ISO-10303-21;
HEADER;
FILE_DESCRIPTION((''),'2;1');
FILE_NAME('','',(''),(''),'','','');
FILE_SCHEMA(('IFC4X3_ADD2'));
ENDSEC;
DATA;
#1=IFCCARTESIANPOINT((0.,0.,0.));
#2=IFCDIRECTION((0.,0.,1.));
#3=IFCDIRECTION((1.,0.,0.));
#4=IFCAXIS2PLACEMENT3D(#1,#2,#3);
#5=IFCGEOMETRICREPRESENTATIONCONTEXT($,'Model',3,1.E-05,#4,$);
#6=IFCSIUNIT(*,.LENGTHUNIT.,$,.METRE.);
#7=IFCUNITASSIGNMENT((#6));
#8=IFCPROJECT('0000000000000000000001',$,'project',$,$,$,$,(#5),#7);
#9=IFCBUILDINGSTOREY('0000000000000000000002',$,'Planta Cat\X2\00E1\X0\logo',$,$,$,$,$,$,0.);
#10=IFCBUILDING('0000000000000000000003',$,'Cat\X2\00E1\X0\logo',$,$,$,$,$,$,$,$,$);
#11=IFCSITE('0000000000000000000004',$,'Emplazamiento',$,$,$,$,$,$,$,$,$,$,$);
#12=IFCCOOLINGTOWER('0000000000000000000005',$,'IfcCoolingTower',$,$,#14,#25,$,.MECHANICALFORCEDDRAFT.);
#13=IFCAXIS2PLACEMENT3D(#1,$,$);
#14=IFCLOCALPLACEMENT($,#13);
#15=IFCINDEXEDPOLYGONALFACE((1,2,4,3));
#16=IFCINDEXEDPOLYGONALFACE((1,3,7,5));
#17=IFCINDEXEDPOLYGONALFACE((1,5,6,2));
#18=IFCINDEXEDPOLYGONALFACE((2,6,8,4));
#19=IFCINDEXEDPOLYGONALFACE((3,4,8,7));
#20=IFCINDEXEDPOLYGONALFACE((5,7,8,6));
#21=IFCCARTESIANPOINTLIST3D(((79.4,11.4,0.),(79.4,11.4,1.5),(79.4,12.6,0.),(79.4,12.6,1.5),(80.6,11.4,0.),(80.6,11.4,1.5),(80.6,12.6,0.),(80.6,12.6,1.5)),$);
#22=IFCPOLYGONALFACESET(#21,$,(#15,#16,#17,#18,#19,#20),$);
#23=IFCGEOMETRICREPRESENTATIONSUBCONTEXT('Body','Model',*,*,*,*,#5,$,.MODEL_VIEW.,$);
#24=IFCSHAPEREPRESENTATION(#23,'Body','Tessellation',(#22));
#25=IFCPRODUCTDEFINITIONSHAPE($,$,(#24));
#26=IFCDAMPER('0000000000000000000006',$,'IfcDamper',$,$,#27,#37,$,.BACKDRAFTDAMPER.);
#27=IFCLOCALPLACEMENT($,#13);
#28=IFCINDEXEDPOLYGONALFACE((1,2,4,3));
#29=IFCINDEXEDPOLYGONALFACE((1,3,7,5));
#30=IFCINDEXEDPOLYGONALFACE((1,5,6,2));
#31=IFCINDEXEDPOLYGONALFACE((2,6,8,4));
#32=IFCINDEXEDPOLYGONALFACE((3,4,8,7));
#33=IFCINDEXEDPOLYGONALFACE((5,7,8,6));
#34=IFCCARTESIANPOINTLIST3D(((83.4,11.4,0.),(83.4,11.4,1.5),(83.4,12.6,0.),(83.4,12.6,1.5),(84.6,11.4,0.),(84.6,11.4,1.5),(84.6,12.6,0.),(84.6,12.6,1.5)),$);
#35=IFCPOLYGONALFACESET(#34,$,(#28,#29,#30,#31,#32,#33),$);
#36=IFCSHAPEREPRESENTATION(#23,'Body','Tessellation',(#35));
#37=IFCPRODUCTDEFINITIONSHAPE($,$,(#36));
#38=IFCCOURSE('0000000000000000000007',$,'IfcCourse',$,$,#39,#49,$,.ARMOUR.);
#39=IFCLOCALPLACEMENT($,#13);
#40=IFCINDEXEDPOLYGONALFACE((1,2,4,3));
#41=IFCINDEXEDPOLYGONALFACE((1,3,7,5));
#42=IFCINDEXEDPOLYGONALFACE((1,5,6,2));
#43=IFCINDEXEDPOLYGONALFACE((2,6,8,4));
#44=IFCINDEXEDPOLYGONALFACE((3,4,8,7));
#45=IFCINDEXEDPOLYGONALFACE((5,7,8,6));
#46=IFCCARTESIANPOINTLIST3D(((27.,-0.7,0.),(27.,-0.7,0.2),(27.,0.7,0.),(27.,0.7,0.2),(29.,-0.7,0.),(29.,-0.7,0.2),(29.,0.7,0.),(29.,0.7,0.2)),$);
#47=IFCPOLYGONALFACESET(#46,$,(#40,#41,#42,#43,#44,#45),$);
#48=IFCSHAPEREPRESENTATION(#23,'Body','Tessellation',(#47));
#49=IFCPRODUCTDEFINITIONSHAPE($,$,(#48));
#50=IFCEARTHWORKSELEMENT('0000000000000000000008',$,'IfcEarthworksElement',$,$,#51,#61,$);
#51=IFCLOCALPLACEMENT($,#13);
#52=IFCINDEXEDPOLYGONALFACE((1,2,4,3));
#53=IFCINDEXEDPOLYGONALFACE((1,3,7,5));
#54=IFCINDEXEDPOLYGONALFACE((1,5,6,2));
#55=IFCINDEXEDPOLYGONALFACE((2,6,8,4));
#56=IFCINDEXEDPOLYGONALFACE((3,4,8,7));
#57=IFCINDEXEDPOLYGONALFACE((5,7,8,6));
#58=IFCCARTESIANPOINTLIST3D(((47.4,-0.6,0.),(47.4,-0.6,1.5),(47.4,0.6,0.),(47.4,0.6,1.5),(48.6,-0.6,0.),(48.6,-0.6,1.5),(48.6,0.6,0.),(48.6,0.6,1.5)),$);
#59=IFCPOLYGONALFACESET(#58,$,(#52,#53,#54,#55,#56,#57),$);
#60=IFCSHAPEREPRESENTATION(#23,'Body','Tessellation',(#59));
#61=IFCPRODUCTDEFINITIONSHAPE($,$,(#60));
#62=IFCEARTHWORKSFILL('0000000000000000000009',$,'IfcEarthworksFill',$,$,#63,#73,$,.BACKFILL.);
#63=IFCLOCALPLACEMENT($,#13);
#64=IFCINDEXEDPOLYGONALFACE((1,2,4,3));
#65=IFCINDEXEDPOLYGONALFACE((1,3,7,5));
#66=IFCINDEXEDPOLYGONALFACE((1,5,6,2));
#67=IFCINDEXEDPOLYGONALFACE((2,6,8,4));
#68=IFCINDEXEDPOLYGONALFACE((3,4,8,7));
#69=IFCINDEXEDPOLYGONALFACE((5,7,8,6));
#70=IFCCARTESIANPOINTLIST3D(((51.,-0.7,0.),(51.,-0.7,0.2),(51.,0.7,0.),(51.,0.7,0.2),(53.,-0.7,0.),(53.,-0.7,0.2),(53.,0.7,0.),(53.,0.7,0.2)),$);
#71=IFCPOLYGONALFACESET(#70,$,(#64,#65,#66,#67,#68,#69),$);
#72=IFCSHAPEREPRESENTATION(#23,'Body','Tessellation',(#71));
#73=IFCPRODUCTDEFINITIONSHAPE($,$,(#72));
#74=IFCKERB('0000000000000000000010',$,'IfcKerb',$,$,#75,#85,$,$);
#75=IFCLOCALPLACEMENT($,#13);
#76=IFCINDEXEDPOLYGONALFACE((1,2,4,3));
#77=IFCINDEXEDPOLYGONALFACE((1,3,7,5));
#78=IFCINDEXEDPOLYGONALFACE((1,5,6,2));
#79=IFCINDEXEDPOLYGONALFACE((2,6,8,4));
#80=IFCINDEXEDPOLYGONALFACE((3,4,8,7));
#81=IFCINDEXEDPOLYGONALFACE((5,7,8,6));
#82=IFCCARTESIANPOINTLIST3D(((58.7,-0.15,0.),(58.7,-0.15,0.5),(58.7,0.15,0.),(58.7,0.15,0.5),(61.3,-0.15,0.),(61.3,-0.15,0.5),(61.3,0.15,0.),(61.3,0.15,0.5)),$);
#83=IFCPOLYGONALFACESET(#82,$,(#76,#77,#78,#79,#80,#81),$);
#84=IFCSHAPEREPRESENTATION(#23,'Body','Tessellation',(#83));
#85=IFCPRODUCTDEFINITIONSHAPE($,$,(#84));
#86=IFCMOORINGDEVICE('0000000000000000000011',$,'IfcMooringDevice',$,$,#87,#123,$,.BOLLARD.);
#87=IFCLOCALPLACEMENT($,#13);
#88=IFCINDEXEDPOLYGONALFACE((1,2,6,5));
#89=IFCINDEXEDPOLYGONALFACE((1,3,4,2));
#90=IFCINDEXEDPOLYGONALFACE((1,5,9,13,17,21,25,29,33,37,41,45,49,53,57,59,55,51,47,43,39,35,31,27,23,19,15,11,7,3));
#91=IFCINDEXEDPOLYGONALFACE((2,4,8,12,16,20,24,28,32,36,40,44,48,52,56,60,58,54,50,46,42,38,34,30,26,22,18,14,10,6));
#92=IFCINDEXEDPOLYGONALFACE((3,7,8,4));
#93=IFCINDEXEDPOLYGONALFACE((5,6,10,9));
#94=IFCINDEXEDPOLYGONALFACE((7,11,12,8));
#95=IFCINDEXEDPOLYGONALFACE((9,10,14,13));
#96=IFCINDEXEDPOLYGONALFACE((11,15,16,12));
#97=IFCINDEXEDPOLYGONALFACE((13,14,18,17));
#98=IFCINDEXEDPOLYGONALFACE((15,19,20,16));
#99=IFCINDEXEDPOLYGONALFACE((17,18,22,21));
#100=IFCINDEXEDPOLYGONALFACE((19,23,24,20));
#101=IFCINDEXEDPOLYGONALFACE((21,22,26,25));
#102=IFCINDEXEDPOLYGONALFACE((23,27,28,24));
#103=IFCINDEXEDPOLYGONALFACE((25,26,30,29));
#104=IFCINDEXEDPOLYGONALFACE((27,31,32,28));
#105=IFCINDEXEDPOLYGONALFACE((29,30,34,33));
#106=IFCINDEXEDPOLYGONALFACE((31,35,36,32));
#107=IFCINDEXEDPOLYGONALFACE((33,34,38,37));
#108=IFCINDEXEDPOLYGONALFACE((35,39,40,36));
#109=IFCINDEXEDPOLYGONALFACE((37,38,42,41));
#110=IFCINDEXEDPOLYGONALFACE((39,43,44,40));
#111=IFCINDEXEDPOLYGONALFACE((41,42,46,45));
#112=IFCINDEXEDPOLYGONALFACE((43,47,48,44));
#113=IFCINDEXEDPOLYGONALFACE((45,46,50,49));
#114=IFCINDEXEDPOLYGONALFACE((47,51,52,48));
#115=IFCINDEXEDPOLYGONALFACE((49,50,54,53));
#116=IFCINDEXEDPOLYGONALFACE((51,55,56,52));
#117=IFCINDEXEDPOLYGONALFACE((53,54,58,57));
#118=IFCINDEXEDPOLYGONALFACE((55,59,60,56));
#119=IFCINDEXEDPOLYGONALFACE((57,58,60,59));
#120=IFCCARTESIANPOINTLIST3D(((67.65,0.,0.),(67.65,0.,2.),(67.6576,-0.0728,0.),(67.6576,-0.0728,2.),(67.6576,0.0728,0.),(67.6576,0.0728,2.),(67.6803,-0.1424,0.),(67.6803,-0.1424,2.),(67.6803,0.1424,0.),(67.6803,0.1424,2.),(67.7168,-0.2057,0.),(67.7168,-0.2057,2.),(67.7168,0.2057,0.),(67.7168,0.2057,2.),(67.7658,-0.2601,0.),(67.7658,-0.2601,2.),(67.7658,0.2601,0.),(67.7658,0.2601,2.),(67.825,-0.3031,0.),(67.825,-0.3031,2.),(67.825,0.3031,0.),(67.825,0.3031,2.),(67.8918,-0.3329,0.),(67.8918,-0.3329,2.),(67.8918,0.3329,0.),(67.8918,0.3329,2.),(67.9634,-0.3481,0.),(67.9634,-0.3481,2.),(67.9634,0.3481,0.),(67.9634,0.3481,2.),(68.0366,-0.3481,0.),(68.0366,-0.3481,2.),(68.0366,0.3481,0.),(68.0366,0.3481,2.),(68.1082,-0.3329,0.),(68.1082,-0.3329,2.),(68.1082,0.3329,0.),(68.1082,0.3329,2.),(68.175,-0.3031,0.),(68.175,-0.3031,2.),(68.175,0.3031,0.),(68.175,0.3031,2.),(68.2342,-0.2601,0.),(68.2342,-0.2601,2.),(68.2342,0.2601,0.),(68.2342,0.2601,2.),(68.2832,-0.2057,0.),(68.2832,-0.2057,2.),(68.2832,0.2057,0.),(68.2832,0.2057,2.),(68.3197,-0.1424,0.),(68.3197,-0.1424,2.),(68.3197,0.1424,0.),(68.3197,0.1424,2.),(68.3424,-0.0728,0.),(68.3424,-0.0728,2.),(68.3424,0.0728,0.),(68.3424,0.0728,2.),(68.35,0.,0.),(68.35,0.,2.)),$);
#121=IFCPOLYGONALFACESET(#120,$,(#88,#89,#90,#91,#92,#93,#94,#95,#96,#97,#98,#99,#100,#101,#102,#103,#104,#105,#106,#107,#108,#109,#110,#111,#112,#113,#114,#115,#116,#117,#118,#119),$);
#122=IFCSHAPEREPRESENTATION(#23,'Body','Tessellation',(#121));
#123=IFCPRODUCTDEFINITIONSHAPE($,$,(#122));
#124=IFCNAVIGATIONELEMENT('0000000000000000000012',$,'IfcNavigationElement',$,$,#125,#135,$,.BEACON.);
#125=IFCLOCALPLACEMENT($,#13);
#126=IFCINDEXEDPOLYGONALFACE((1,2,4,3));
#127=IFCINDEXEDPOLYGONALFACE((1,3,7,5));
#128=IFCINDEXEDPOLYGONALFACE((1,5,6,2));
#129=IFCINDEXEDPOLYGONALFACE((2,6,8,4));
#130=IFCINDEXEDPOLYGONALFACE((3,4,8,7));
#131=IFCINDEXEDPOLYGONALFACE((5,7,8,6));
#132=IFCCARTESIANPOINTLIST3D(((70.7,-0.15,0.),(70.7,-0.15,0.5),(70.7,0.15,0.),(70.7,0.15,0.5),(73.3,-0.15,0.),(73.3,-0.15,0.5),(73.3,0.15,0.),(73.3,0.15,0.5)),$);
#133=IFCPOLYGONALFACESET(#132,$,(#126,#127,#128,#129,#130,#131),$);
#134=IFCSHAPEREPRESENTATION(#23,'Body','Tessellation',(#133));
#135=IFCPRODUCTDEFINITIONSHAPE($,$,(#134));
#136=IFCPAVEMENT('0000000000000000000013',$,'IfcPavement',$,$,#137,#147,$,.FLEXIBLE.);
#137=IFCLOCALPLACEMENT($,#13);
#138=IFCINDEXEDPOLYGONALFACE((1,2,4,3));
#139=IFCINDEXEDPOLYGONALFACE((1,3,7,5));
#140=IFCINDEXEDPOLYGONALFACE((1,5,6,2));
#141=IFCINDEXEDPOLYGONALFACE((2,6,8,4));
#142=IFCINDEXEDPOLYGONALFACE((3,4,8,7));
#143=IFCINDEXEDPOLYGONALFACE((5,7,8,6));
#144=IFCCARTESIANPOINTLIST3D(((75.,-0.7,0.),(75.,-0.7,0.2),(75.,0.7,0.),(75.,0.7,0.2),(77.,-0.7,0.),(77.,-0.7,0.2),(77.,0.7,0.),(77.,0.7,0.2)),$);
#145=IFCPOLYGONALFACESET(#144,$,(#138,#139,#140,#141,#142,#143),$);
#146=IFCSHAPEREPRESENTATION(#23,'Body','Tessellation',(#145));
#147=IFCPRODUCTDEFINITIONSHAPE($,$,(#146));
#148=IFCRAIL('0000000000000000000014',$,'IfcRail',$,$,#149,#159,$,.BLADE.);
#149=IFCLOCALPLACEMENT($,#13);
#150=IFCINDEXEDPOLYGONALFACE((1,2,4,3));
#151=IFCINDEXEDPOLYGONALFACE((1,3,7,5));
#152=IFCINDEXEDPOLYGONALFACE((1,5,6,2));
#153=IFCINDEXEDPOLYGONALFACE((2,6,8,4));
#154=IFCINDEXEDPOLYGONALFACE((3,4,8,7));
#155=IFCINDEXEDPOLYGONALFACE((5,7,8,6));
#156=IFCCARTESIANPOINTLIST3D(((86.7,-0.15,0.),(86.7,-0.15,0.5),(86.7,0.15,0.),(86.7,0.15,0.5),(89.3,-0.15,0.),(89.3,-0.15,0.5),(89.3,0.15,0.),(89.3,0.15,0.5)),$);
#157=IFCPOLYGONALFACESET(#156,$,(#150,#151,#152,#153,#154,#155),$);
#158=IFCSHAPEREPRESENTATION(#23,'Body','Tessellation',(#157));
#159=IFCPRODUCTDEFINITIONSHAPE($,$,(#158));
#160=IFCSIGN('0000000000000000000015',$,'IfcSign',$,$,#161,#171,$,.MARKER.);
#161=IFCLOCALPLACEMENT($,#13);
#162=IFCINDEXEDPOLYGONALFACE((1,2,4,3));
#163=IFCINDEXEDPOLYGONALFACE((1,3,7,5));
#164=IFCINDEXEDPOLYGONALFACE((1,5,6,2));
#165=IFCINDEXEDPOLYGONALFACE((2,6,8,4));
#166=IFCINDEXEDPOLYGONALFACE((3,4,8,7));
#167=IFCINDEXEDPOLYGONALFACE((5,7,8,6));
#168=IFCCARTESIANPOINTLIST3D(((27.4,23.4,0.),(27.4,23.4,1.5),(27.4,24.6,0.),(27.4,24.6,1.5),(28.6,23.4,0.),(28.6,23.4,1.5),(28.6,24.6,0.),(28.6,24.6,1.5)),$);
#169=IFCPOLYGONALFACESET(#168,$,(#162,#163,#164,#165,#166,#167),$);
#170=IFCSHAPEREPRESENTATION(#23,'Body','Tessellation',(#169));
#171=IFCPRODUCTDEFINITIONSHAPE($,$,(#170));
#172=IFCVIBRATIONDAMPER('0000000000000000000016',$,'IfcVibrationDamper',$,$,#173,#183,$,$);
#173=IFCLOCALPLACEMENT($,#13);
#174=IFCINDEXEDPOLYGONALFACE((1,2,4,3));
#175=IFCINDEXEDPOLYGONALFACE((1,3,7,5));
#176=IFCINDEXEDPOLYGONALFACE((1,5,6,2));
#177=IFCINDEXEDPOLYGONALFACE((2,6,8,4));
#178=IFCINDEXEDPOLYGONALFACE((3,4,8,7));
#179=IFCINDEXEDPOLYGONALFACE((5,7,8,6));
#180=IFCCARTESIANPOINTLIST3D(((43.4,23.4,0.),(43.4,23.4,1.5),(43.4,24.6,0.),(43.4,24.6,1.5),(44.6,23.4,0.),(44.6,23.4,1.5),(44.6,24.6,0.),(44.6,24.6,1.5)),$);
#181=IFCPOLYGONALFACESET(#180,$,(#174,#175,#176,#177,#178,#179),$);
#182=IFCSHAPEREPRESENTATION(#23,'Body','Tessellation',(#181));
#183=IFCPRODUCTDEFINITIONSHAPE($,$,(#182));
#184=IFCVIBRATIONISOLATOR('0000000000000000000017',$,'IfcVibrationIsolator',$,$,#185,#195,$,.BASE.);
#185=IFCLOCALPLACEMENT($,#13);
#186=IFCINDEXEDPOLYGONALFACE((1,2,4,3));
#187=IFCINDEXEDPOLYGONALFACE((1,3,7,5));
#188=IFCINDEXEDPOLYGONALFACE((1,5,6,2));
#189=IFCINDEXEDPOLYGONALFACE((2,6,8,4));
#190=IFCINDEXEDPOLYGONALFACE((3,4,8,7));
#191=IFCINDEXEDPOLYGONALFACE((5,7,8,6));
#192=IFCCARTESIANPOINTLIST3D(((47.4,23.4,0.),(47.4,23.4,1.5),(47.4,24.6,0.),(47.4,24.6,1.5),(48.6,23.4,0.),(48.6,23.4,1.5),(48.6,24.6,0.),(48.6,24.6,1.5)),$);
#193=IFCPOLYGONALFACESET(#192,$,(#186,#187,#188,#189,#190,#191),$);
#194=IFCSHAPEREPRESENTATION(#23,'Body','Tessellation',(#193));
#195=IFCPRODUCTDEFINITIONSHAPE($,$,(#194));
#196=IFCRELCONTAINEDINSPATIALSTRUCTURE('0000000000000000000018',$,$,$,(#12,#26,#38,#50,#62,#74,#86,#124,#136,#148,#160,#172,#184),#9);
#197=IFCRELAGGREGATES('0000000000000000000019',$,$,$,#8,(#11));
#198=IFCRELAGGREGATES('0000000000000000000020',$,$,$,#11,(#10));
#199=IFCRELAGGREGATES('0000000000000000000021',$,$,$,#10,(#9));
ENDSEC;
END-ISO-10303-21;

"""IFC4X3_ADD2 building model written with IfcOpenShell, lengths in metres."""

from ifc_helpers import new_model, si_unit, frame, origin, origin_with_axes, origin_2d, place, context, subcontext, project, spatial, rectangle, circle, extrude, element, save


model = new_model("IFC4X3_ADD2")

# Units and contexts
model_context = context("Model", 3, precision=1e-05, world=origin_with_axes())
body_context = subcontext(model_context, "Body", "Model", "MODEL_VIEW")
ifc_project = project(units=[si_unit("LENGTHUNIT", "METRE")], contexts=[model_context])

# Site, building, storey
site = spatial("IfcSite", under=ifc_project, Name="Emplazamiento")
building = spatial("IfcBuilding", under=site, Name="Catálogo")
storey = spatial("IfcBuildingStorey", under=building, Name="Planta Catálogo", Elevation=0.0)

# Cooling tower
cooling_tower_placement = place(None, frame((80.0, 12.0, 0.0), z_axis=(0.0, 0.0, 1.0), x_axis=(1.0, 0.0, 0.0)))
element("IfcCoolingTower", 1, at=cooling_tower_placement, inside=storey, Name="IfcCoolingTower", PredefinedType="MECHANICALFORCEDDRAFT", context=body_context, shape_type="SweptSolid", body=[
    extrude(rectangle(XDim=1.2, YDim=1.2, at=origin_2d()), origin(), (0.0, 0.0, 1.0), 1.5),
])

# Damper
damper_placement = place(None, frame((84.0, 12.0, 0.0), z_axis=(0.0, 0.0, 1.0), x_axis=(1.0, 0.0, 0.0)))
element("IfcDamper", 2, at=damper_placement, inside=storey, Name="IfcDamper", PredefinedType="BACKDRAFTDAMPER", context=body_context, shape_type="SweptSolid", body=[
    extrude(rectangle(XDim=1.2, YDim=1.2, at=origin_2d()), origin(), (0.0, 0.0, 1.0), 1.5),
])

# Course
course_placement = place(None, frame((28.0, 0.0, 0.0), z_axis=(0.0, 0.0, 1.0), x_axis=(1.0, 0.0, 0.0)))
element("IfcCourse", 3, at=course_placement, inside=storey, Name="IfcCourse", PredefinedType="ARMOUR", context=body_context, shape_type="SweptSolid", body=[
    extrude(rectangle(XDim=2.0, YDim=1.4, at=origin_2d()), origin(), (0.0, 0.0, 1.0), 0.2),
])

# Earthworks element
earthworks_element_placement = place(None, frame((48.0, 0.0, 0.0), z_axis=(0.0, 0.0, 1.0), x_axis=(1.0, 0.0, 0.0)))
element("IfcEarthworksElement", 4, at=earthworks_element_placement, inside=storey, Name="IfcEarthworksElement", context=body_context, shape_type="SweptSolid", body=[
    extrude(rectangle(XDim=1.2, YDim=1.2, at=origin_2d()), origin(), (0.0, 0.0, 1.0), 1.5),
])

# Earthworks fill
earthworks_fill_placement = place(None, frame((52.0, 0.0, 0.0), z_axis=(0.0, 0.0, 1.0), x_axis=(1.0, 0.0, 0.0)))
element("IfcEarthworksFill", 5, at=earthworks_fill_placement, inside=storey, Name="IfcEarthworksFill", PredefinedType="BACKFILL", context=body_context, shape_type="SweptSolid", body=[
    extrude(rectangle(XDim=2.0, YDim=1.4, at=origin_2d()), origin(), (0.0, 0.0, 1.0), 0.2),
])

# Kerb
kerb_placement = place(None, frame((60.0, 0.0, 0.0), z_axis=(0.0, 0.0, 1.0), x_axis=(1.0, 0.0, 0.0)))
element("IfcKerb", 6, at=kerb_placement, inside=storey, Name="IfcKerb", context=body_context, shape_type="SweptSolid", body=[
    extrude(rectangle(XDim=2.6, YDim=0.3, at=origin_2d()), origin(), (0.0, 0.0, 1.0), 0.5),
])

# Mooring device
mooring_device_placement = place(None, frame((68.0, 0.0, 0.0), z_axis=(0.0, 0.0, 1.0), x_axis=(1.0, 0.0, 0.0)))
element("IfcMooringDevice", 7, at=mooring_device_placement, inside=storey, Name="IfcMooringDevice", PredefinedType="BOLLARD", context=body_context, shape_type="SweptSolid", body=[
    extrude(circle(Radius=0.35, at=origin_2d()), origin(), (0.0, 0.0, 1.0), 2.0),
])

# Navigation element
navigation_element_placement = place(None, frame((72.0, 0.0, 0.0), z_axis=(0.0, 0.0, 1.0), x_axis=(1.0, 0.0, 0.0)))
element("IfcNavigationElement", 8, at=navigation_element_placement, inside=storey, Name="IfcNavigationElement", PredefinedType="BEACON", context=body_context, shape_type="SweptSolid", body=[
    extrude(rectangle(XDim=2.6, YDim=0.3, at=origin_2d()), origin(), (0.0, 0.0, 1.0), 0.5),
])

# Pavement
pavement_placement = place(None, frame((76.0, 0.0, 0.0), z_axis=(0.0, 0.0, 1.0), x_axis=(1.0, 0.0, 0.0)))
element("IfcPavement", 9, at=pavement_placement, inside=storey, Name="IfcPavement", PredefinedType="FLEXIBLE", context=body_context, shape_type="SweptSolid", body=[
    extrude(rectangle(XDim=2.0, YDim=1.4, at=origin_2d()), origin(), (0.0, 0.0, 1.0), 0.2),
])

# Rail
rail_placement = place(None, frame((88.0, 0.0, 0.0), z_axis=(0.0, 0.0, 1.0), x_axis=(1.0, 0.0, 0.0)))
element("IfcRail", 10, at=rail_placement, inside=storey, Name="IfcRail", PredefinedType="BLADE", context=body_context, shape_type="SweptSolid", body=[
    extrude(rectangle(XDim=2.6, YDim=0.3, at=origin_2d()), origin(), (0.0, 0.0, 1.0), 0.5),
])

# Sign
sign_placement = place(None, frame((28.0, 24.0, 0.0), z_axis=(0.0, 0.0, 1.0), x_axis=(1.0, 0.0, 0.0)))
element("IfcSign", 11, at=sign_placement, inside=storey, Name="IfcSign", PredefinedType="MARKER", context=body_context, shape_type="SweptSolid", body=[
    extrude(rectangle(XDim=1.2, YDim=1.2, at=origin_2d()), origin(), (0.0, 0.0, 1.0), 1.5),
])

# Vibration damper
vibration_damper_placement = place(None, frame((44.0, 24.0, 0.0), z_axis=(0.0, 0.0, 1.0), x_axis=(1.0, 0.0, 0.0)))
element("IfcVibrationDamper", 12, at=vibration_damper_placement, inside=storey, Name="IfcVibrationDamper", context=body_context, shape_type="SweptSolid", body=[
    extrude(rectangle(XDim=1.2, YDim=1.2, at=origin_2d()), origin(), (0.0, 0.0, 1.0), 1.5),
])

# Vibration isolator
vibration_isolator_placement = place(None, frame((48.0, 24.0, 0.0), z_axis=(0.0, 0.0, 1.0), x_axis=(1.0, 0.0, 0.0)))
element("IfcVibrationIsolator", 13, at=vibration_isolator_placement, inside=storey, Name="IfcVibrationIsolator", PredefinedType="BASE", context=body_context, shape_type="SweptSolid", body=[
    extrude(rectangle(XDim=1.2, YDim=1.2, at=origin_2d()), origin(), (0.0, 0.0, 1.0), 1.5),
])

save(model, "model.ifc")
